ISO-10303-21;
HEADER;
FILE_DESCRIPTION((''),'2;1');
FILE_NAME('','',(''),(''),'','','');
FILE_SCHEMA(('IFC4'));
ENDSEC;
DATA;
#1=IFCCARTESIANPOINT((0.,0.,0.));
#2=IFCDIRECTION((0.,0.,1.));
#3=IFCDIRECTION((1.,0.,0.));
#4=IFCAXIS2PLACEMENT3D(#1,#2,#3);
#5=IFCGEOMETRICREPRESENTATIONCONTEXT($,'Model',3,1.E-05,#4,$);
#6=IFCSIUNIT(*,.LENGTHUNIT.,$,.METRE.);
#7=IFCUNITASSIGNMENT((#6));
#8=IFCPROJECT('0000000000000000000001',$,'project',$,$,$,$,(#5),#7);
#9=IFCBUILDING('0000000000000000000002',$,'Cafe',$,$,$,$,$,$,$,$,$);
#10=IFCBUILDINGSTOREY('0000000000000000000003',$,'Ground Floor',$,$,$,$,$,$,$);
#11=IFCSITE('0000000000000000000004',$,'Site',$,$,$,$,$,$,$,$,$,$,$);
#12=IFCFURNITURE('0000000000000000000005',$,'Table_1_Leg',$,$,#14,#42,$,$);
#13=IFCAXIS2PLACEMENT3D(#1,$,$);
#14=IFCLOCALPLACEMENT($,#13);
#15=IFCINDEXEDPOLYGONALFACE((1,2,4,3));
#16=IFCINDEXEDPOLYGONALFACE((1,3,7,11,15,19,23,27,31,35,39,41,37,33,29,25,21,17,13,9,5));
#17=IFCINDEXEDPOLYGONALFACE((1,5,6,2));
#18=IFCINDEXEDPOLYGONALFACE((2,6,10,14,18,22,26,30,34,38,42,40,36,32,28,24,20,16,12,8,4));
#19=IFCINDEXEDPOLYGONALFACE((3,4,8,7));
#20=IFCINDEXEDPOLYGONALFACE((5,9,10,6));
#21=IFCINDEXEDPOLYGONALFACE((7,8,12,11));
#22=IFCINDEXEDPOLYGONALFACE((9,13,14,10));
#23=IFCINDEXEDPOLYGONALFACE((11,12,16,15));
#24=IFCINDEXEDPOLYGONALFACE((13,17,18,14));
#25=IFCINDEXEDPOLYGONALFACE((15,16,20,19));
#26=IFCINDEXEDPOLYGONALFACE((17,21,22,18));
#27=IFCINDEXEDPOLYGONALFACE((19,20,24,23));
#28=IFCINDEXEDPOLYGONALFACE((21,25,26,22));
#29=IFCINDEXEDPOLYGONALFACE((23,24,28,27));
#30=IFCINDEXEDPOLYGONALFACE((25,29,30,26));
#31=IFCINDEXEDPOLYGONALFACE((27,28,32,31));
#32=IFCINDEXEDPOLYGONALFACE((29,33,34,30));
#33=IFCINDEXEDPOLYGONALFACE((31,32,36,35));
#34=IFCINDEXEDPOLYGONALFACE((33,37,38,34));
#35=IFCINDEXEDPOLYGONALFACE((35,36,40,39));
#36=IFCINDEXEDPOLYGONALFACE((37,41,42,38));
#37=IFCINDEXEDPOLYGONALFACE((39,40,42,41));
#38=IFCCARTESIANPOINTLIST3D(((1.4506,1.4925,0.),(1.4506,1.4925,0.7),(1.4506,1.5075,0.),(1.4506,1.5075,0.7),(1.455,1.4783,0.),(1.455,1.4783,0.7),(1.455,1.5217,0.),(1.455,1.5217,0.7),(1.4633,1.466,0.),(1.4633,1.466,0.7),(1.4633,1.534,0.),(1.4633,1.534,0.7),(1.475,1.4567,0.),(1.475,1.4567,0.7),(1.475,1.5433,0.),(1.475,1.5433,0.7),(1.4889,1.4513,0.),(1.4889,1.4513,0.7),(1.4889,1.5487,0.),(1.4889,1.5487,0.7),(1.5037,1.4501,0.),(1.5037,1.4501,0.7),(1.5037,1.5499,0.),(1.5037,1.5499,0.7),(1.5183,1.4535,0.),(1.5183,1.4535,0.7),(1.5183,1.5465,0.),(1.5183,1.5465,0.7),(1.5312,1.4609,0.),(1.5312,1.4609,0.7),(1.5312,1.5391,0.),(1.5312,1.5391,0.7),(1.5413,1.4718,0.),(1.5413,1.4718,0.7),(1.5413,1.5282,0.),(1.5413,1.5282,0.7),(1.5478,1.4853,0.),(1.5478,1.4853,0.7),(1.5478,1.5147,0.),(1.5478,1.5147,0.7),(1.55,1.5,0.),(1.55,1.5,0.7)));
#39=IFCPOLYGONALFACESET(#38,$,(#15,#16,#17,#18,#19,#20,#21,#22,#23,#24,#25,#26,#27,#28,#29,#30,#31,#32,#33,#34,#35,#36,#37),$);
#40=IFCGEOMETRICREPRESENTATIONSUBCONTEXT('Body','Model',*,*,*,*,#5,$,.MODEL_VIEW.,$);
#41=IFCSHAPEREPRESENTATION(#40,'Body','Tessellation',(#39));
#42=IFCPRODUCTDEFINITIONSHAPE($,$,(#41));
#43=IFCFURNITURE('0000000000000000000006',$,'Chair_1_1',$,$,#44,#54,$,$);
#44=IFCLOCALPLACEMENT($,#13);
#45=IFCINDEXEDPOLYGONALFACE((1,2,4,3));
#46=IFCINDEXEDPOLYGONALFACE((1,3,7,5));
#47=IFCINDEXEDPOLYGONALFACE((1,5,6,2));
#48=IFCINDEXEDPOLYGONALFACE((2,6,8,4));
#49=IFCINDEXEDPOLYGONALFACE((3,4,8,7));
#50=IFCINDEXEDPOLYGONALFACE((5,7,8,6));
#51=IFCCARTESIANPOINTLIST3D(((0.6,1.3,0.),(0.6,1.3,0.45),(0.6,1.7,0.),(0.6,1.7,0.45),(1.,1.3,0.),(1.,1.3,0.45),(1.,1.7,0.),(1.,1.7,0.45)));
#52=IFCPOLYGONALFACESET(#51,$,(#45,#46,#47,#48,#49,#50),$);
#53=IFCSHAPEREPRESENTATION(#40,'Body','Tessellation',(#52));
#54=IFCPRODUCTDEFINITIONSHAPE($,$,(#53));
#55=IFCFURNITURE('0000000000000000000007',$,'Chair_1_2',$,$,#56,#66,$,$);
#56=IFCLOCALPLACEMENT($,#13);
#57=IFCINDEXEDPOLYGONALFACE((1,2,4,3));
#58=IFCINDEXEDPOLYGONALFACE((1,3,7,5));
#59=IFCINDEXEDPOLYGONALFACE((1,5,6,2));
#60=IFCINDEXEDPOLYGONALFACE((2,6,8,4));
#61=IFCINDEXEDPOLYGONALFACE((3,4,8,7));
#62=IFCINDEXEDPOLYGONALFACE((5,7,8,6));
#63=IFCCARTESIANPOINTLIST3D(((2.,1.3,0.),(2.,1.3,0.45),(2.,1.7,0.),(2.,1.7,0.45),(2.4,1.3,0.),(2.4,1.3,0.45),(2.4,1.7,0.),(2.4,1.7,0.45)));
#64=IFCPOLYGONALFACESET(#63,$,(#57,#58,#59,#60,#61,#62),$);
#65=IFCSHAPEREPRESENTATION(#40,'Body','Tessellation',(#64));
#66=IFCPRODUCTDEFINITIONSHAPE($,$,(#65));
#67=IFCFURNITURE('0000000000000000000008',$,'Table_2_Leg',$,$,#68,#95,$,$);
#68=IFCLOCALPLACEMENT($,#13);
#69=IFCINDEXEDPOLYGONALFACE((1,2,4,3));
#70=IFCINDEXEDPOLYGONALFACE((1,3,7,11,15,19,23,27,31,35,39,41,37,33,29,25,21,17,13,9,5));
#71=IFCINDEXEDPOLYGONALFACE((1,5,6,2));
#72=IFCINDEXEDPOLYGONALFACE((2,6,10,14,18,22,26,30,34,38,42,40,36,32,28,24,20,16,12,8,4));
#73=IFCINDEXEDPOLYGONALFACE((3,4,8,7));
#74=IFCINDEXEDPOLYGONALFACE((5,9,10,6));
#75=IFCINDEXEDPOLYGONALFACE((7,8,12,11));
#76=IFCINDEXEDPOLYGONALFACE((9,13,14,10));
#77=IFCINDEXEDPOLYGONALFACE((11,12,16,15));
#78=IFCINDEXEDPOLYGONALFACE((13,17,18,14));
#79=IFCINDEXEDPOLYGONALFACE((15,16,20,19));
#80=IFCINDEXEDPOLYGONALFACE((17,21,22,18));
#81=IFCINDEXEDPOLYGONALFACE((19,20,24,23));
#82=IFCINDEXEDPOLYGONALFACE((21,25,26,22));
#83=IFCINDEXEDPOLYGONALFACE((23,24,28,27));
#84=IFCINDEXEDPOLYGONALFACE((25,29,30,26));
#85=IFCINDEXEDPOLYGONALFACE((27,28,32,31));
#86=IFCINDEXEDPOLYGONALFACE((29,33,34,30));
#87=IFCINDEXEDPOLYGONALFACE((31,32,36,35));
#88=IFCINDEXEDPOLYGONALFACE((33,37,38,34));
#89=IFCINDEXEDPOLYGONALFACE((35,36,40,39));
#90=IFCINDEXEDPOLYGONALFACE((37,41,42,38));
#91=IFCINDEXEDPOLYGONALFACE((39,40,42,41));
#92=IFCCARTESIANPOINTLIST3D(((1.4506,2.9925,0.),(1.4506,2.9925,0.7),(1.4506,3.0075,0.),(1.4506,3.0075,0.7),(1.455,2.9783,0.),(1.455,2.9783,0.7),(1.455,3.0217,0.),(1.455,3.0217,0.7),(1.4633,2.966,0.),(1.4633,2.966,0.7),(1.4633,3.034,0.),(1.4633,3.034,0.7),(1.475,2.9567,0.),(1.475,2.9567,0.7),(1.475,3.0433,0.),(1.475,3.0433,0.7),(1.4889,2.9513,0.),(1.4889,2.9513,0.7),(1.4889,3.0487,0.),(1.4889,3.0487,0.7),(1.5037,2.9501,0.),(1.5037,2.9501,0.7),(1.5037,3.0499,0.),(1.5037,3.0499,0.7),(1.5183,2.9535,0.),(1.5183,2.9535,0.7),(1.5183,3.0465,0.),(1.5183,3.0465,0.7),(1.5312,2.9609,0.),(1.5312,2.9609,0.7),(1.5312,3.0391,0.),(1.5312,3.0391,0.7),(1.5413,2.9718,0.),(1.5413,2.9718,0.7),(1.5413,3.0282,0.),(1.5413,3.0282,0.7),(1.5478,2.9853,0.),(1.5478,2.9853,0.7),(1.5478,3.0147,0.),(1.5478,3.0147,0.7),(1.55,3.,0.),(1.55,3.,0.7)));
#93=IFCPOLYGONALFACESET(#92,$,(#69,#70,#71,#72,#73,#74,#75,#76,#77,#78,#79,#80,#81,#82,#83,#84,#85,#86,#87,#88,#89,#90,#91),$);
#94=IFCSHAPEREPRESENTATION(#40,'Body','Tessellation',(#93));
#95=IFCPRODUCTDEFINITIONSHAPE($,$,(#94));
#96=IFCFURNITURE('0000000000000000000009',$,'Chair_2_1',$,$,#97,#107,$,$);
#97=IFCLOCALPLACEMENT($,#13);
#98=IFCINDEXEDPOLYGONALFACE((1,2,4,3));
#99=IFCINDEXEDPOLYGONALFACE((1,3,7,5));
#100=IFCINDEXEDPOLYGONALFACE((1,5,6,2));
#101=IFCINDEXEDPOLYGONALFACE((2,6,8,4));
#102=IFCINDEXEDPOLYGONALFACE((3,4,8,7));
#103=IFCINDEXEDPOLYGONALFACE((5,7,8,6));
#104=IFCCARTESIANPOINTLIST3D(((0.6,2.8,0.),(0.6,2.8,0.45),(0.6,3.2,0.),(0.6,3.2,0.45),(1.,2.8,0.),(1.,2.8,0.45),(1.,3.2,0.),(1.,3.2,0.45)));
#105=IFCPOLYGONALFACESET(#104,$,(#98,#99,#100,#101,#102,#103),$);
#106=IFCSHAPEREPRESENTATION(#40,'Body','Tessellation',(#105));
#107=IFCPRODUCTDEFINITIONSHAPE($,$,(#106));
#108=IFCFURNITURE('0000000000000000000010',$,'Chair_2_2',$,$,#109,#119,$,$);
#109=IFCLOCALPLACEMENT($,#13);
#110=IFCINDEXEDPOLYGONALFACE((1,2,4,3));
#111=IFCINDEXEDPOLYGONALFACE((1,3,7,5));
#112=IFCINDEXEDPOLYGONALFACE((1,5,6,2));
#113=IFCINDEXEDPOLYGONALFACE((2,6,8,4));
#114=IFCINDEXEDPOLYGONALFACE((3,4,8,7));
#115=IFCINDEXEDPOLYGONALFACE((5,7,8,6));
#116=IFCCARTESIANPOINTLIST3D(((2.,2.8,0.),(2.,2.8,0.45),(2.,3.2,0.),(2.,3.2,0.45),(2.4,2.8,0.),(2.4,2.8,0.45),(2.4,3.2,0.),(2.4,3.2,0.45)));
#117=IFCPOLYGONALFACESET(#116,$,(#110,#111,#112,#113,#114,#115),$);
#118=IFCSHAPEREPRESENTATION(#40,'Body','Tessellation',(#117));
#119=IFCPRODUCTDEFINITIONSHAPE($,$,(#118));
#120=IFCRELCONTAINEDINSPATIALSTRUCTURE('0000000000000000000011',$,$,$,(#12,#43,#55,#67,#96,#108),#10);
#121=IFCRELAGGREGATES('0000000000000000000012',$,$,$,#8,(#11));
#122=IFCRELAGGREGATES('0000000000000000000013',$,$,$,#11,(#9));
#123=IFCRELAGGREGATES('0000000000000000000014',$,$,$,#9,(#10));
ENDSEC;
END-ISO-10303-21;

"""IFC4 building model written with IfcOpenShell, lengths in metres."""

from ifc_helpers import new_model, si_unit, frame, origin, origin_with_axes, origin_2d, place, context, subcontext, project, spatial, rectangle, circle, extrude, element, save


model = new_model("IFC4")

# Units and contexts
model_context = context("Model", 3, precision=1e-05, world=origin_with_axes())
body_context = subcontext(model_context, "Body", "Model", "MODEL_VIEW")
ifc_project = project(units=[si_unit("LENGTHUNIT", "METRE")], contexts=[model_context])

# Site, building, storey
site = spatial("IfcSite", under=ifc_project, Name="Site")
building = spatial("IfcBuilding", under=site, Name="Cafe")
storey = spatial("IfcBuildingStorey", under=building, Name="Ground Floor")

# Furniture
furniture_1_placement = place(None, frame((1.5, 1.5, 0.0), z_axis=(0.0, 0.0, 1.0), x_axis=(1.0, 0.0, 0.0)))
element("IfcFurniture", 1, at=furniture_1_placement, inside=storey, Name="Table_1_Leg", context=body_context, shape_type="SweptSolid", body=[
    extrude(circle(Radius=0.05, at=origin_2d()), origin(), (0.0, 0.0, 1.0), 0.7),
])
furniture_2_placement = place(None, frame((0.8, 1.5, 0.0), z_axis=(0.0, 0.0, 1.0), x_axis=(1.0, 0.0, 0.0)))
element("IfcFurniture", 2, at=furniture_2_placement, inside=storey, Name="Chair_1_1", context=body_context, shape_type="SweptSolid", body=[
    extrude(rectangle(XDim=0.4, YDim=0.4, at=origin_2d()), origin(), (0.0, 0.0, 1.0), 0.45),
])
furniture_3_placement = place(None, frame((2.2, 1.5, 0.0), z_axis=(0.0, 0.0, 1.0), x_axis=(1.0, 0.0, 0.0)))
element("IfcFurniture", 3, at=furniture_3_placement, inside=storey, Name="Chair_1_2", context=body_context, shape_type="SweptSolid", body=[
    extrude(rectangle(XDim=0.4, YDim=0.4, at=origin_2d()), origin(), (0.0, 0.0, 1.0), 0.45),
])
furniture_4_placement = place(None, frame((1.5, 3.0, 0.0), z_axis=(0.0, 0.0, 1.0), x_axis=(1.0, 0.0, 0.0)))
element("IfcFurniture", 4, at=furniture_4_placement, inside=storey, Name="Table_2_Leg", context=body_context, shape_type="SweptSolid", body=[
    extrude(circle(Radius=0.05, at=origin_2d()), origin(), (0.0, 0.0, 1.0), 0.7),
])
furniture_5_placement = place(None, frame((0.8, 3.0, 0.0), z_axis=(0.0, 0.0, 1.0), x_axis=(1.0, 0.0, 0.0)))
element("IfcFurniture", 5, at=furniture_5_placement, inside=storey, Name="Chair_2_1", context=body_context, shape_type="SweptSolid", body=[
    extrude(rectangle(XDim=0.4, YDim=0.4, at=origin_2d()), origin(), (0.0, 0.0, 1.0), 0.45),
])
furniture_6_placement = place(None, frame((2.2, 3.0, 0.0), z_axis=(0.0, 0.0, 1.0), x_axis=(1.0, 0.0, 0.0)))
element("IfcFurniture", 6, at=furniture_6_placement, inside=storey, Name="Chair_2_2", context=body_context, shape_type="SweptSolid", body=[
    extrude(rectangle(XDim=0.4, YDim=0.4, at=origin_2d()), origin(), (0.0, 0.0, 1.0), 0.45),
])

save(model, "model.ifc")
